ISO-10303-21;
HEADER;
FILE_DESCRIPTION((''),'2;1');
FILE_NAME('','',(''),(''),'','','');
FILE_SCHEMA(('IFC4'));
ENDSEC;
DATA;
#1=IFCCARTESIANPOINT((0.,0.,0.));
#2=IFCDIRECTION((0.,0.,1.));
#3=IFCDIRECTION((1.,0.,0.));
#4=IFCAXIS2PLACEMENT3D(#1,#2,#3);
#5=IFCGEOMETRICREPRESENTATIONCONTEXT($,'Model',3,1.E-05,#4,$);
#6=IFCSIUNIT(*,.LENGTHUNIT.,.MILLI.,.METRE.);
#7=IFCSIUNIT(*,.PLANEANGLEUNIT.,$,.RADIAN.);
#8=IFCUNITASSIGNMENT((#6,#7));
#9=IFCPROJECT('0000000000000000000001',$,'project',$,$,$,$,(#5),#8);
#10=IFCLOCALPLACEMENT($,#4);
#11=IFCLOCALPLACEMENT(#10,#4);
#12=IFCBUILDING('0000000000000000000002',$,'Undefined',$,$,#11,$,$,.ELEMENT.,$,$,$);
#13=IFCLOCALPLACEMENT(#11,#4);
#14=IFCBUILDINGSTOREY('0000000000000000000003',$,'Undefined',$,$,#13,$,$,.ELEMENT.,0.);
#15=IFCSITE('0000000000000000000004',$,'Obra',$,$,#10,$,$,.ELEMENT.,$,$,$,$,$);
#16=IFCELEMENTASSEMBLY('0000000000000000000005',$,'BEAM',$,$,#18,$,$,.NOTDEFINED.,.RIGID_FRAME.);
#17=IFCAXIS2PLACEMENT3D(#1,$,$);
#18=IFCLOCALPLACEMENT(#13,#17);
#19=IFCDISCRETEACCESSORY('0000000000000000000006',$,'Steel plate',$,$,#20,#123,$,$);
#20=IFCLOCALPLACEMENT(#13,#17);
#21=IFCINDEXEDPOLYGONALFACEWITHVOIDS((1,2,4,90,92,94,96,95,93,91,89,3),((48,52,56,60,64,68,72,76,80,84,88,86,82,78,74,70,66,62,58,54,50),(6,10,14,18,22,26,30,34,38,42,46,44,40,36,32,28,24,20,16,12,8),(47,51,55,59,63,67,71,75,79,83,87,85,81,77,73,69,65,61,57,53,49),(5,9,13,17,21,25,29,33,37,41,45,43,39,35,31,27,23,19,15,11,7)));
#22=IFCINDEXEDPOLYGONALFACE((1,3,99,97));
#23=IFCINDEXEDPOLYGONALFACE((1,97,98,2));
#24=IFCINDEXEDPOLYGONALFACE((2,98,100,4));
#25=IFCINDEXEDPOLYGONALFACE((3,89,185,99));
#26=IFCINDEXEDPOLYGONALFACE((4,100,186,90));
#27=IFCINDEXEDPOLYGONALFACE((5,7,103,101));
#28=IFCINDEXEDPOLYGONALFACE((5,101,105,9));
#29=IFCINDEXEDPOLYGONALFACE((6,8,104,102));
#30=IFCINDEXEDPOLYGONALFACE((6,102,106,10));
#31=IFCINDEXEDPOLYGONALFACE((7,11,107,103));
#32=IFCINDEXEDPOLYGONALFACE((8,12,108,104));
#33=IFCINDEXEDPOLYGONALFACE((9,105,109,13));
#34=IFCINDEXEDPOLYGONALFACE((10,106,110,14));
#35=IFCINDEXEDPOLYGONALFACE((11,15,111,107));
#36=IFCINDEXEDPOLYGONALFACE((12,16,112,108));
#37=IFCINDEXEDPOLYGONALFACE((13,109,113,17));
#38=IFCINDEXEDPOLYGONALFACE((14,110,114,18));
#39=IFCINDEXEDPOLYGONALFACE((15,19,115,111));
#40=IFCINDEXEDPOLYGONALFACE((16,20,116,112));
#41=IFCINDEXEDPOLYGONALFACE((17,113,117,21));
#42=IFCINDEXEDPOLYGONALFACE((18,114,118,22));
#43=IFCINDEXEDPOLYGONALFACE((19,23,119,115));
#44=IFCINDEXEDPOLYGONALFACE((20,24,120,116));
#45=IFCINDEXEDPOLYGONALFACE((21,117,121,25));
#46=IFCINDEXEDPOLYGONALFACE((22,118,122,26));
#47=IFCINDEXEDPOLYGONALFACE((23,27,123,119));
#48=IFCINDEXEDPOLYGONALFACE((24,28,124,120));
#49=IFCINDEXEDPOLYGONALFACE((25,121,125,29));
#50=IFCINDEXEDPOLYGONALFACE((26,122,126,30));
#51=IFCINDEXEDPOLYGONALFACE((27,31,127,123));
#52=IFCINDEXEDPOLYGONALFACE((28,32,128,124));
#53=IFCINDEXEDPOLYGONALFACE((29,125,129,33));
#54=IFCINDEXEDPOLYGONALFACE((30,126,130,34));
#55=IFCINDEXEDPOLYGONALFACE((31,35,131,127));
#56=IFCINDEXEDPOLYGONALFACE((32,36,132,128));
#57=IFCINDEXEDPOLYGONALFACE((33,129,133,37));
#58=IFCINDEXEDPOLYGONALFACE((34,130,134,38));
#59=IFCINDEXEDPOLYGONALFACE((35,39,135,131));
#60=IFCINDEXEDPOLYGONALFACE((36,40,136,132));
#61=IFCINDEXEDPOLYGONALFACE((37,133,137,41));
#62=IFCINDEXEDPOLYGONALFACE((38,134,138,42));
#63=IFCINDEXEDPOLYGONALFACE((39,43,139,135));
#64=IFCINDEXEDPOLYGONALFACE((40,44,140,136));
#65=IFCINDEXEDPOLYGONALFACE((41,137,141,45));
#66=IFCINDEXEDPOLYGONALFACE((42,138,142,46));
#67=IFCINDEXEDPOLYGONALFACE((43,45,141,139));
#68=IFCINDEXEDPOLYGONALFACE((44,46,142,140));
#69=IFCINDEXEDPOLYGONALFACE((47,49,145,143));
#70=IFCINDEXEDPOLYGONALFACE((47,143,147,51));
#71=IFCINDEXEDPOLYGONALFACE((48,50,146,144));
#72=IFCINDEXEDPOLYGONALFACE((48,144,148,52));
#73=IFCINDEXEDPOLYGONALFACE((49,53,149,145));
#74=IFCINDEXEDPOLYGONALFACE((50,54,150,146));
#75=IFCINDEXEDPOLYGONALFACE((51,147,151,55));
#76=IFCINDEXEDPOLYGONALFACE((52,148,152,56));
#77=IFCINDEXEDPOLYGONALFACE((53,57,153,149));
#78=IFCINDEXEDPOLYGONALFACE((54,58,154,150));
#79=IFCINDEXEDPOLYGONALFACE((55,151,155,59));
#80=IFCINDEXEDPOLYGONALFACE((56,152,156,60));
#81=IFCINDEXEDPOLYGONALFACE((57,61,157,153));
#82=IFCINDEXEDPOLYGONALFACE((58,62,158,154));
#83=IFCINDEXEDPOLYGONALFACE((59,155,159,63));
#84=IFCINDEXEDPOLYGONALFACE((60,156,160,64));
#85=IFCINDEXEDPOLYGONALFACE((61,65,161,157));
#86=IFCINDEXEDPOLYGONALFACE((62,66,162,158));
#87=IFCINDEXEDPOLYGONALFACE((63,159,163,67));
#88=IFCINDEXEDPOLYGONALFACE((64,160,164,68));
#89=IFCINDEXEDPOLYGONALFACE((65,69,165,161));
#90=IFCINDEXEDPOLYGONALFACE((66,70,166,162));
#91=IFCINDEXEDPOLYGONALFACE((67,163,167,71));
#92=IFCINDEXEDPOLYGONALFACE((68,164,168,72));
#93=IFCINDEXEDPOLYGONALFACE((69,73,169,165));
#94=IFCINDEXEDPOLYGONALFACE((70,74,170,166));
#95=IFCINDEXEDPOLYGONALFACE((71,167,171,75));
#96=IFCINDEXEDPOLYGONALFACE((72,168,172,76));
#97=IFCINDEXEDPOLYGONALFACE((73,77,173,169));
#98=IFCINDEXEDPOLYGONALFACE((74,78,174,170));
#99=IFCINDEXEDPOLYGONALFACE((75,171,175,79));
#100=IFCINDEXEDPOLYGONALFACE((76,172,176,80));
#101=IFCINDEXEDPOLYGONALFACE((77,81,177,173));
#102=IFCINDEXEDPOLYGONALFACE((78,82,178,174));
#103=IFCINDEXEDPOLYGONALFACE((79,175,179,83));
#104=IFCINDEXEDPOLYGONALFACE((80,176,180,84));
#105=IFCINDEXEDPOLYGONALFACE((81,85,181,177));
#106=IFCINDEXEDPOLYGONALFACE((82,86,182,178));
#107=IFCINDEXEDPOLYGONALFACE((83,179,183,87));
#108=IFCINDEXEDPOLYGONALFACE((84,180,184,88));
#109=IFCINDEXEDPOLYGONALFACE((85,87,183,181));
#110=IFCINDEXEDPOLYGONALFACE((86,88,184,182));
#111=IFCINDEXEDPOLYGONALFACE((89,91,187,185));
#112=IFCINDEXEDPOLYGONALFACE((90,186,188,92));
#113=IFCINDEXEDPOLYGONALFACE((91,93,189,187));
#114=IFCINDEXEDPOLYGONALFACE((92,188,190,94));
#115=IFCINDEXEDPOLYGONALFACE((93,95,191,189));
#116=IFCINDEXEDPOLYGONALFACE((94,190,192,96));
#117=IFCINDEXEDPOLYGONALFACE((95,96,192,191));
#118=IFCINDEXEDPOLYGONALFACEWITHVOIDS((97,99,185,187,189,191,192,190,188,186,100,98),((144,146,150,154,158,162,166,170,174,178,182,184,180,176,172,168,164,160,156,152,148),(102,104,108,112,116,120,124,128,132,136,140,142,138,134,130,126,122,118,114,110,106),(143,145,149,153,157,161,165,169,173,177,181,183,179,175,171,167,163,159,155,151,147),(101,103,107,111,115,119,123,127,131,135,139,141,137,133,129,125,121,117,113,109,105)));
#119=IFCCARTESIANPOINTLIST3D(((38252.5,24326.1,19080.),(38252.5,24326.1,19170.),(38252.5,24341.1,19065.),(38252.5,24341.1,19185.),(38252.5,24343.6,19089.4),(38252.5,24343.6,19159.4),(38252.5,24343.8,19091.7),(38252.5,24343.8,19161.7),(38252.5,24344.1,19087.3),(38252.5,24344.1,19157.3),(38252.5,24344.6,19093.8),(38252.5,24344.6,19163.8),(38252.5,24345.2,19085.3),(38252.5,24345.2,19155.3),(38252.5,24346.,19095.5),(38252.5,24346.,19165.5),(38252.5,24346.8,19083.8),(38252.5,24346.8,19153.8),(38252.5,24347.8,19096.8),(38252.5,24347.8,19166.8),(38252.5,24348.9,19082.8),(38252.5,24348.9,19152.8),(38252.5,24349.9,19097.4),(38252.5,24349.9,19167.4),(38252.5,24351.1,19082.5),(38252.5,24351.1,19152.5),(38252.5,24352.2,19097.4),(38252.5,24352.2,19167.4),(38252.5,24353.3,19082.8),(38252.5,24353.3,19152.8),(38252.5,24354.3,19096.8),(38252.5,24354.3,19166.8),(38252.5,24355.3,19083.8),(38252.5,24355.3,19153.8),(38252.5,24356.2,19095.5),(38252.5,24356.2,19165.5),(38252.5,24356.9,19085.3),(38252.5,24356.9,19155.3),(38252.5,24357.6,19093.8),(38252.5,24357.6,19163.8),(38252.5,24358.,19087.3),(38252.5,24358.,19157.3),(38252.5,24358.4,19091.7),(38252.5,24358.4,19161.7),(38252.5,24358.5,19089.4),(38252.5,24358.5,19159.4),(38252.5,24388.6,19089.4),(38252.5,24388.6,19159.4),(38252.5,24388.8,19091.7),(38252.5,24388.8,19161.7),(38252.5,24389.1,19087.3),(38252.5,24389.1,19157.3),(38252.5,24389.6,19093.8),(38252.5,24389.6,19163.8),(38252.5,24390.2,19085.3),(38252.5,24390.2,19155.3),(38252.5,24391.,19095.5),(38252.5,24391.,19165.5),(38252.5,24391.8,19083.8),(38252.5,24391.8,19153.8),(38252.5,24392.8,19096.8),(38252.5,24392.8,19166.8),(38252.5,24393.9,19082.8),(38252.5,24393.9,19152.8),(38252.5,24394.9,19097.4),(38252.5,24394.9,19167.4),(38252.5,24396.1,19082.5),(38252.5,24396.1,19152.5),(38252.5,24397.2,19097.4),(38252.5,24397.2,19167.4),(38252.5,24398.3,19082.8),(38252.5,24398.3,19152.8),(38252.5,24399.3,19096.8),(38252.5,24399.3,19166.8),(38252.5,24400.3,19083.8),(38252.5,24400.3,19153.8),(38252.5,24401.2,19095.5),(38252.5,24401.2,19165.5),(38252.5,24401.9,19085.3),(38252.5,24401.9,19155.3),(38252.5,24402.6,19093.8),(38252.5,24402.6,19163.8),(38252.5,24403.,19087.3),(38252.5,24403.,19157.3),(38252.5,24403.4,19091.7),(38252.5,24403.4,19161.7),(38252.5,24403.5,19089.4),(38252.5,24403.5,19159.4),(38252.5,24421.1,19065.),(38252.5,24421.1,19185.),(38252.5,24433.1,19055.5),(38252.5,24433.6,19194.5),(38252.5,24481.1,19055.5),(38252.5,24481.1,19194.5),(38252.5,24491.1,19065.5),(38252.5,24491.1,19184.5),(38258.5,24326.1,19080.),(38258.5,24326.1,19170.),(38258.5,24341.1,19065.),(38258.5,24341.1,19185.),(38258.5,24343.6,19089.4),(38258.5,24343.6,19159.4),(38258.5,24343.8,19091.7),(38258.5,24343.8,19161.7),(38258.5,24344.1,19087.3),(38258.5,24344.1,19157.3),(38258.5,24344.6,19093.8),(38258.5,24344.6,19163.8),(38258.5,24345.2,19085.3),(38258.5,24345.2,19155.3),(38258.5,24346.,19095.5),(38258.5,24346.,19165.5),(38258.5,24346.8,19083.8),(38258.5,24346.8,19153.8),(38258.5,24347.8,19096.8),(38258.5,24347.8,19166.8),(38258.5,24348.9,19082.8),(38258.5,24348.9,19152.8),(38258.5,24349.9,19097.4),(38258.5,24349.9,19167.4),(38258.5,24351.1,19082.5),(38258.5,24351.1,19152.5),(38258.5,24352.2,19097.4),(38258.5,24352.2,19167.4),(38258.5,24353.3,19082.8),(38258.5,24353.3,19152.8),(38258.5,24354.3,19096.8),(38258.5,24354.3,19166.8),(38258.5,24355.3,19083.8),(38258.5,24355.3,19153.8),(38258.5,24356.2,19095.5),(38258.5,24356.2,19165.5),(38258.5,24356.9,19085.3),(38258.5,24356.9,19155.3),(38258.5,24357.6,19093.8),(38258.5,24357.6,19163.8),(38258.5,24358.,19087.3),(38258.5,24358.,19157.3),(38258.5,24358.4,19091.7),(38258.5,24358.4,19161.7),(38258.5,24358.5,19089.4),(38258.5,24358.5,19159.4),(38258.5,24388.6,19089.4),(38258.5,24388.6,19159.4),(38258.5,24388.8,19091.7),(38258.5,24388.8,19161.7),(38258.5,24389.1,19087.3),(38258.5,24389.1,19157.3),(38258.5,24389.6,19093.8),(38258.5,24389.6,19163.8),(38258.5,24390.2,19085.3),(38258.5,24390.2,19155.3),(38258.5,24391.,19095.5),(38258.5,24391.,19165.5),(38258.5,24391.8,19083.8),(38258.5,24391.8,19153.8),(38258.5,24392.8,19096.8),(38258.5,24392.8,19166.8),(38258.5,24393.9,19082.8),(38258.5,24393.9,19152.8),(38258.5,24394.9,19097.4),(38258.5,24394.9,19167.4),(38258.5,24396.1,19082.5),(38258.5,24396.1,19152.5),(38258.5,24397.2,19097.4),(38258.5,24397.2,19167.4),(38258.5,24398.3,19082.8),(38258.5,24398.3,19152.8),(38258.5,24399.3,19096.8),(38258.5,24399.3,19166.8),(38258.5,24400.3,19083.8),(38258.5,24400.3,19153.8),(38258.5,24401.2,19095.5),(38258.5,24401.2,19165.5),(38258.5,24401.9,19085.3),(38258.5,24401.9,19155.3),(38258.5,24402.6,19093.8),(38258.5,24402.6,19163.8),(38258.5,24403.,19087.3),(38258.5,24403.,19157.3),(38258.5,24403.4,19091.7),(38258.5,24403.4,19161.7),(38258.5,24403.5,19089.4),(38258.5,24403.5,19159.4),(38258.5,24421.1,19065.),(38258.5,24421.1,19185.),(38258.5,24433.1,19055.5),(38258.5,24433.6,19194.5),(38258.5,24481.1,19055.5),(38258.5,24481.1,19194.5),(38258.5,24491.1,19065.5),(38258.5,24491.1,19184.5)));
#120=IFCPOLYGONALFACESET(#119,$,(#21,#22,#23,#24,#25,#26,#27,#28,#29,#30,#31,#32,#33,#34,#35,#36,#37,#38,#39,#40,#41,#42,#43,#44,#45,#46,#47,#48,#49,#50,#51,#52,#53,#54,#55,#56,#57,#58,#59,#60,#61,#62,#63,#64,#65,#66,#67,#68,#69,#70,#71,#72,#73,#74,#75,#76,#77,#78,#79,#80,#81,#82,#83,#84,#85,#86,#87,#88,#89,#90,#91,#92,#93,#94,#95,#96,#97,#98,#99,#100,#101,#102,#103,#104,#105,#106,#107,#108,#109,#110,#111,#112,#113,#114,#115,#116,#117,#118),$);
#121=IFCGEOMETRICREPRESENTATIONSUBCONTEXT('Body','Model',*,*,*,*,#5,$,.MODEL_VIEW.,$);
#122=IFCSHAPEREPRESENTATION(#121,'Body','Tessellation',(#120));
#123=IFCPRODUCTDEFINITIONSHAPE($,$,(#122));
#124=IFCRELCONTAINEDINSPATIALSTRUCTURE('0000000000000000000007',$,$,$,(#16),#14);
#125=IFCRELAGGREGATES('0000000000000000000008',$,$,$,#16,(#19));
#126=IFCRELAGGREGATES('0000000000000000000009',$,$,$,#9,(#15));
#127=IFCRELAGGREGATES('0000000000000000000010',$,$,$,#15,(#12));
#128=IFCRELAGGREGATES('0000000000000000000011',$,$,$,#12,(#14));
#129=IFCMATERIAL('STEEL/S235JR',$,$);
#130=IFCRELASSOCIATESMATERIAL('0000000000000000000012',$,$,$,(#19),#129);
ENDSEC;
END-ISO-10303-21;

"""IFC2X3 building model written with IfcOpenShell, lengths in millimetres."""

from ifc_helpers import new_model, si_unit, frame, origin_with_axes, origin_2d_with_axis, place, context, subcontext, project, spatial, polyline, circle, outline, extrude, source, transform, mapped, material, element, aggregate, save


model = new_model("IFC2X3")

# Units and contexts
model_context = context("Model", 3, precision=1e-05, world=origin_with_axes())
body_context = subcontext(model_context, "Body", "Model", "MODEL_VIEW")
ifc_project = project(units=[si_unit("LENGTHUNIT", "METRE", prefix="MILLI"), si_unit("PLANEANGLEUNIT", "RADIAN")], contexts=[model_context])

# Site, building, storey
site_placement = place(None, origin_with_axes())
site = spatial("IfcSite", under=ifc_project, at=site_placement, Name="Obra", CompositionType="ELEMENT")
building_placement = place(site_placement, origin_with_axes())
building = spatial("IfcBuilding", under=site, at=building_placement, Name="Undefined", CompositionType="ELEMENT")
storey_placement = place(building_placement, origin_with_axes())
storey = spatial("IfcBuildingStorey", under=building, at=storey_placement, Name="Undefined", CompositionType="ELEMENT", Elevation=0.0)

# Shared definitions
ifc_material_1 = material(Name="STEEL/S235JR")

# Element assembly
assembly_1_placement = place(storey_placement, origin_with_axes())
assembly_1 = element("IfcElementAssembly", 1, at=assembly_1_placement, inside=storey, Name="BEAM", AssemblyPlace="NOTDEFINED", PredefinedType="RIGID_FRAME")

# Shared definitions
shared_shape_1 = source(origin_with_axes(), body_context, "Body", "SweptSolid", [
    extrude(circle(Radius=7.5, at=origin_2d_with_axis()), frame((0.0, 2.4, 0.0), z_axis=(0.0, 1.0, 0.0), x_axis=(1.0, 0.0, 0.0)), (0.0, 0.0, 1.0), 6.2),
])

# Discrete accessory, opening
discrete_accessory_1_placement = place(assembly_1_placement, frame((38255.5, 24491.1, 19065.5), z_axis=(-1.0, 0.0, 0.0), x_axis=(0.0, -0.707107, -0.707107)))
discrete_accessory_1 = element("IfcDiscreteAccessory", 2, at=discrete_accessory_1_placement, material=ifc_material_1, Name="Steel plate", context=body_context, shape_type="SweptSolid", body=[
    extrude(outline(polyline([(0.0, 0.0), (14.1, 0.0), (48.1, 33.9), (49.9, 49.1), (106.4, 105.7), (106.4, 126.9), (42.8, 190.6), (21.6, 190.6), (-35.0, 134.0), (-50.6, 131.9), (-84.1, 98.3), (-84.1, 84.1), (0.0, 0.0)])), frame((0.0, 0.0, -3.0), z_axis=(0.0, 0.0, 1.0), x_axis=(1.0, 0.0, 0.0)), (0.0, 0.0, 1.0), 6.0),
])
opening_1_placement = place(assembly_1_placement, frame((38250.0, 24373.6, 19160.0), z_axis=(0.0, -1.0, 0.0), x_axis=(0.0, 0.0, -1.0)))
element("IfcOpeningElement", 3, at=opening_1_placement, cuts=discrete_accessory_1, ObjectType="Opening", context=body_context, shape_type="MappedRepresentation", body=[
    mapped(shared_shape_1, transform((0.0, 0.0, -22.5))),
    mapped(shared_shape_1, transform((70.0, 0.0, -22.5))),
    mapped(shared_shape_1, transform((0.0, 0.0, 22.5))),
    mapped(shared_shape_1, transform((70.0, 0.0, 22.5))),
])

aggregate(assembly_1, [discrete_accessory_1])

save(model, "model.ifc")
